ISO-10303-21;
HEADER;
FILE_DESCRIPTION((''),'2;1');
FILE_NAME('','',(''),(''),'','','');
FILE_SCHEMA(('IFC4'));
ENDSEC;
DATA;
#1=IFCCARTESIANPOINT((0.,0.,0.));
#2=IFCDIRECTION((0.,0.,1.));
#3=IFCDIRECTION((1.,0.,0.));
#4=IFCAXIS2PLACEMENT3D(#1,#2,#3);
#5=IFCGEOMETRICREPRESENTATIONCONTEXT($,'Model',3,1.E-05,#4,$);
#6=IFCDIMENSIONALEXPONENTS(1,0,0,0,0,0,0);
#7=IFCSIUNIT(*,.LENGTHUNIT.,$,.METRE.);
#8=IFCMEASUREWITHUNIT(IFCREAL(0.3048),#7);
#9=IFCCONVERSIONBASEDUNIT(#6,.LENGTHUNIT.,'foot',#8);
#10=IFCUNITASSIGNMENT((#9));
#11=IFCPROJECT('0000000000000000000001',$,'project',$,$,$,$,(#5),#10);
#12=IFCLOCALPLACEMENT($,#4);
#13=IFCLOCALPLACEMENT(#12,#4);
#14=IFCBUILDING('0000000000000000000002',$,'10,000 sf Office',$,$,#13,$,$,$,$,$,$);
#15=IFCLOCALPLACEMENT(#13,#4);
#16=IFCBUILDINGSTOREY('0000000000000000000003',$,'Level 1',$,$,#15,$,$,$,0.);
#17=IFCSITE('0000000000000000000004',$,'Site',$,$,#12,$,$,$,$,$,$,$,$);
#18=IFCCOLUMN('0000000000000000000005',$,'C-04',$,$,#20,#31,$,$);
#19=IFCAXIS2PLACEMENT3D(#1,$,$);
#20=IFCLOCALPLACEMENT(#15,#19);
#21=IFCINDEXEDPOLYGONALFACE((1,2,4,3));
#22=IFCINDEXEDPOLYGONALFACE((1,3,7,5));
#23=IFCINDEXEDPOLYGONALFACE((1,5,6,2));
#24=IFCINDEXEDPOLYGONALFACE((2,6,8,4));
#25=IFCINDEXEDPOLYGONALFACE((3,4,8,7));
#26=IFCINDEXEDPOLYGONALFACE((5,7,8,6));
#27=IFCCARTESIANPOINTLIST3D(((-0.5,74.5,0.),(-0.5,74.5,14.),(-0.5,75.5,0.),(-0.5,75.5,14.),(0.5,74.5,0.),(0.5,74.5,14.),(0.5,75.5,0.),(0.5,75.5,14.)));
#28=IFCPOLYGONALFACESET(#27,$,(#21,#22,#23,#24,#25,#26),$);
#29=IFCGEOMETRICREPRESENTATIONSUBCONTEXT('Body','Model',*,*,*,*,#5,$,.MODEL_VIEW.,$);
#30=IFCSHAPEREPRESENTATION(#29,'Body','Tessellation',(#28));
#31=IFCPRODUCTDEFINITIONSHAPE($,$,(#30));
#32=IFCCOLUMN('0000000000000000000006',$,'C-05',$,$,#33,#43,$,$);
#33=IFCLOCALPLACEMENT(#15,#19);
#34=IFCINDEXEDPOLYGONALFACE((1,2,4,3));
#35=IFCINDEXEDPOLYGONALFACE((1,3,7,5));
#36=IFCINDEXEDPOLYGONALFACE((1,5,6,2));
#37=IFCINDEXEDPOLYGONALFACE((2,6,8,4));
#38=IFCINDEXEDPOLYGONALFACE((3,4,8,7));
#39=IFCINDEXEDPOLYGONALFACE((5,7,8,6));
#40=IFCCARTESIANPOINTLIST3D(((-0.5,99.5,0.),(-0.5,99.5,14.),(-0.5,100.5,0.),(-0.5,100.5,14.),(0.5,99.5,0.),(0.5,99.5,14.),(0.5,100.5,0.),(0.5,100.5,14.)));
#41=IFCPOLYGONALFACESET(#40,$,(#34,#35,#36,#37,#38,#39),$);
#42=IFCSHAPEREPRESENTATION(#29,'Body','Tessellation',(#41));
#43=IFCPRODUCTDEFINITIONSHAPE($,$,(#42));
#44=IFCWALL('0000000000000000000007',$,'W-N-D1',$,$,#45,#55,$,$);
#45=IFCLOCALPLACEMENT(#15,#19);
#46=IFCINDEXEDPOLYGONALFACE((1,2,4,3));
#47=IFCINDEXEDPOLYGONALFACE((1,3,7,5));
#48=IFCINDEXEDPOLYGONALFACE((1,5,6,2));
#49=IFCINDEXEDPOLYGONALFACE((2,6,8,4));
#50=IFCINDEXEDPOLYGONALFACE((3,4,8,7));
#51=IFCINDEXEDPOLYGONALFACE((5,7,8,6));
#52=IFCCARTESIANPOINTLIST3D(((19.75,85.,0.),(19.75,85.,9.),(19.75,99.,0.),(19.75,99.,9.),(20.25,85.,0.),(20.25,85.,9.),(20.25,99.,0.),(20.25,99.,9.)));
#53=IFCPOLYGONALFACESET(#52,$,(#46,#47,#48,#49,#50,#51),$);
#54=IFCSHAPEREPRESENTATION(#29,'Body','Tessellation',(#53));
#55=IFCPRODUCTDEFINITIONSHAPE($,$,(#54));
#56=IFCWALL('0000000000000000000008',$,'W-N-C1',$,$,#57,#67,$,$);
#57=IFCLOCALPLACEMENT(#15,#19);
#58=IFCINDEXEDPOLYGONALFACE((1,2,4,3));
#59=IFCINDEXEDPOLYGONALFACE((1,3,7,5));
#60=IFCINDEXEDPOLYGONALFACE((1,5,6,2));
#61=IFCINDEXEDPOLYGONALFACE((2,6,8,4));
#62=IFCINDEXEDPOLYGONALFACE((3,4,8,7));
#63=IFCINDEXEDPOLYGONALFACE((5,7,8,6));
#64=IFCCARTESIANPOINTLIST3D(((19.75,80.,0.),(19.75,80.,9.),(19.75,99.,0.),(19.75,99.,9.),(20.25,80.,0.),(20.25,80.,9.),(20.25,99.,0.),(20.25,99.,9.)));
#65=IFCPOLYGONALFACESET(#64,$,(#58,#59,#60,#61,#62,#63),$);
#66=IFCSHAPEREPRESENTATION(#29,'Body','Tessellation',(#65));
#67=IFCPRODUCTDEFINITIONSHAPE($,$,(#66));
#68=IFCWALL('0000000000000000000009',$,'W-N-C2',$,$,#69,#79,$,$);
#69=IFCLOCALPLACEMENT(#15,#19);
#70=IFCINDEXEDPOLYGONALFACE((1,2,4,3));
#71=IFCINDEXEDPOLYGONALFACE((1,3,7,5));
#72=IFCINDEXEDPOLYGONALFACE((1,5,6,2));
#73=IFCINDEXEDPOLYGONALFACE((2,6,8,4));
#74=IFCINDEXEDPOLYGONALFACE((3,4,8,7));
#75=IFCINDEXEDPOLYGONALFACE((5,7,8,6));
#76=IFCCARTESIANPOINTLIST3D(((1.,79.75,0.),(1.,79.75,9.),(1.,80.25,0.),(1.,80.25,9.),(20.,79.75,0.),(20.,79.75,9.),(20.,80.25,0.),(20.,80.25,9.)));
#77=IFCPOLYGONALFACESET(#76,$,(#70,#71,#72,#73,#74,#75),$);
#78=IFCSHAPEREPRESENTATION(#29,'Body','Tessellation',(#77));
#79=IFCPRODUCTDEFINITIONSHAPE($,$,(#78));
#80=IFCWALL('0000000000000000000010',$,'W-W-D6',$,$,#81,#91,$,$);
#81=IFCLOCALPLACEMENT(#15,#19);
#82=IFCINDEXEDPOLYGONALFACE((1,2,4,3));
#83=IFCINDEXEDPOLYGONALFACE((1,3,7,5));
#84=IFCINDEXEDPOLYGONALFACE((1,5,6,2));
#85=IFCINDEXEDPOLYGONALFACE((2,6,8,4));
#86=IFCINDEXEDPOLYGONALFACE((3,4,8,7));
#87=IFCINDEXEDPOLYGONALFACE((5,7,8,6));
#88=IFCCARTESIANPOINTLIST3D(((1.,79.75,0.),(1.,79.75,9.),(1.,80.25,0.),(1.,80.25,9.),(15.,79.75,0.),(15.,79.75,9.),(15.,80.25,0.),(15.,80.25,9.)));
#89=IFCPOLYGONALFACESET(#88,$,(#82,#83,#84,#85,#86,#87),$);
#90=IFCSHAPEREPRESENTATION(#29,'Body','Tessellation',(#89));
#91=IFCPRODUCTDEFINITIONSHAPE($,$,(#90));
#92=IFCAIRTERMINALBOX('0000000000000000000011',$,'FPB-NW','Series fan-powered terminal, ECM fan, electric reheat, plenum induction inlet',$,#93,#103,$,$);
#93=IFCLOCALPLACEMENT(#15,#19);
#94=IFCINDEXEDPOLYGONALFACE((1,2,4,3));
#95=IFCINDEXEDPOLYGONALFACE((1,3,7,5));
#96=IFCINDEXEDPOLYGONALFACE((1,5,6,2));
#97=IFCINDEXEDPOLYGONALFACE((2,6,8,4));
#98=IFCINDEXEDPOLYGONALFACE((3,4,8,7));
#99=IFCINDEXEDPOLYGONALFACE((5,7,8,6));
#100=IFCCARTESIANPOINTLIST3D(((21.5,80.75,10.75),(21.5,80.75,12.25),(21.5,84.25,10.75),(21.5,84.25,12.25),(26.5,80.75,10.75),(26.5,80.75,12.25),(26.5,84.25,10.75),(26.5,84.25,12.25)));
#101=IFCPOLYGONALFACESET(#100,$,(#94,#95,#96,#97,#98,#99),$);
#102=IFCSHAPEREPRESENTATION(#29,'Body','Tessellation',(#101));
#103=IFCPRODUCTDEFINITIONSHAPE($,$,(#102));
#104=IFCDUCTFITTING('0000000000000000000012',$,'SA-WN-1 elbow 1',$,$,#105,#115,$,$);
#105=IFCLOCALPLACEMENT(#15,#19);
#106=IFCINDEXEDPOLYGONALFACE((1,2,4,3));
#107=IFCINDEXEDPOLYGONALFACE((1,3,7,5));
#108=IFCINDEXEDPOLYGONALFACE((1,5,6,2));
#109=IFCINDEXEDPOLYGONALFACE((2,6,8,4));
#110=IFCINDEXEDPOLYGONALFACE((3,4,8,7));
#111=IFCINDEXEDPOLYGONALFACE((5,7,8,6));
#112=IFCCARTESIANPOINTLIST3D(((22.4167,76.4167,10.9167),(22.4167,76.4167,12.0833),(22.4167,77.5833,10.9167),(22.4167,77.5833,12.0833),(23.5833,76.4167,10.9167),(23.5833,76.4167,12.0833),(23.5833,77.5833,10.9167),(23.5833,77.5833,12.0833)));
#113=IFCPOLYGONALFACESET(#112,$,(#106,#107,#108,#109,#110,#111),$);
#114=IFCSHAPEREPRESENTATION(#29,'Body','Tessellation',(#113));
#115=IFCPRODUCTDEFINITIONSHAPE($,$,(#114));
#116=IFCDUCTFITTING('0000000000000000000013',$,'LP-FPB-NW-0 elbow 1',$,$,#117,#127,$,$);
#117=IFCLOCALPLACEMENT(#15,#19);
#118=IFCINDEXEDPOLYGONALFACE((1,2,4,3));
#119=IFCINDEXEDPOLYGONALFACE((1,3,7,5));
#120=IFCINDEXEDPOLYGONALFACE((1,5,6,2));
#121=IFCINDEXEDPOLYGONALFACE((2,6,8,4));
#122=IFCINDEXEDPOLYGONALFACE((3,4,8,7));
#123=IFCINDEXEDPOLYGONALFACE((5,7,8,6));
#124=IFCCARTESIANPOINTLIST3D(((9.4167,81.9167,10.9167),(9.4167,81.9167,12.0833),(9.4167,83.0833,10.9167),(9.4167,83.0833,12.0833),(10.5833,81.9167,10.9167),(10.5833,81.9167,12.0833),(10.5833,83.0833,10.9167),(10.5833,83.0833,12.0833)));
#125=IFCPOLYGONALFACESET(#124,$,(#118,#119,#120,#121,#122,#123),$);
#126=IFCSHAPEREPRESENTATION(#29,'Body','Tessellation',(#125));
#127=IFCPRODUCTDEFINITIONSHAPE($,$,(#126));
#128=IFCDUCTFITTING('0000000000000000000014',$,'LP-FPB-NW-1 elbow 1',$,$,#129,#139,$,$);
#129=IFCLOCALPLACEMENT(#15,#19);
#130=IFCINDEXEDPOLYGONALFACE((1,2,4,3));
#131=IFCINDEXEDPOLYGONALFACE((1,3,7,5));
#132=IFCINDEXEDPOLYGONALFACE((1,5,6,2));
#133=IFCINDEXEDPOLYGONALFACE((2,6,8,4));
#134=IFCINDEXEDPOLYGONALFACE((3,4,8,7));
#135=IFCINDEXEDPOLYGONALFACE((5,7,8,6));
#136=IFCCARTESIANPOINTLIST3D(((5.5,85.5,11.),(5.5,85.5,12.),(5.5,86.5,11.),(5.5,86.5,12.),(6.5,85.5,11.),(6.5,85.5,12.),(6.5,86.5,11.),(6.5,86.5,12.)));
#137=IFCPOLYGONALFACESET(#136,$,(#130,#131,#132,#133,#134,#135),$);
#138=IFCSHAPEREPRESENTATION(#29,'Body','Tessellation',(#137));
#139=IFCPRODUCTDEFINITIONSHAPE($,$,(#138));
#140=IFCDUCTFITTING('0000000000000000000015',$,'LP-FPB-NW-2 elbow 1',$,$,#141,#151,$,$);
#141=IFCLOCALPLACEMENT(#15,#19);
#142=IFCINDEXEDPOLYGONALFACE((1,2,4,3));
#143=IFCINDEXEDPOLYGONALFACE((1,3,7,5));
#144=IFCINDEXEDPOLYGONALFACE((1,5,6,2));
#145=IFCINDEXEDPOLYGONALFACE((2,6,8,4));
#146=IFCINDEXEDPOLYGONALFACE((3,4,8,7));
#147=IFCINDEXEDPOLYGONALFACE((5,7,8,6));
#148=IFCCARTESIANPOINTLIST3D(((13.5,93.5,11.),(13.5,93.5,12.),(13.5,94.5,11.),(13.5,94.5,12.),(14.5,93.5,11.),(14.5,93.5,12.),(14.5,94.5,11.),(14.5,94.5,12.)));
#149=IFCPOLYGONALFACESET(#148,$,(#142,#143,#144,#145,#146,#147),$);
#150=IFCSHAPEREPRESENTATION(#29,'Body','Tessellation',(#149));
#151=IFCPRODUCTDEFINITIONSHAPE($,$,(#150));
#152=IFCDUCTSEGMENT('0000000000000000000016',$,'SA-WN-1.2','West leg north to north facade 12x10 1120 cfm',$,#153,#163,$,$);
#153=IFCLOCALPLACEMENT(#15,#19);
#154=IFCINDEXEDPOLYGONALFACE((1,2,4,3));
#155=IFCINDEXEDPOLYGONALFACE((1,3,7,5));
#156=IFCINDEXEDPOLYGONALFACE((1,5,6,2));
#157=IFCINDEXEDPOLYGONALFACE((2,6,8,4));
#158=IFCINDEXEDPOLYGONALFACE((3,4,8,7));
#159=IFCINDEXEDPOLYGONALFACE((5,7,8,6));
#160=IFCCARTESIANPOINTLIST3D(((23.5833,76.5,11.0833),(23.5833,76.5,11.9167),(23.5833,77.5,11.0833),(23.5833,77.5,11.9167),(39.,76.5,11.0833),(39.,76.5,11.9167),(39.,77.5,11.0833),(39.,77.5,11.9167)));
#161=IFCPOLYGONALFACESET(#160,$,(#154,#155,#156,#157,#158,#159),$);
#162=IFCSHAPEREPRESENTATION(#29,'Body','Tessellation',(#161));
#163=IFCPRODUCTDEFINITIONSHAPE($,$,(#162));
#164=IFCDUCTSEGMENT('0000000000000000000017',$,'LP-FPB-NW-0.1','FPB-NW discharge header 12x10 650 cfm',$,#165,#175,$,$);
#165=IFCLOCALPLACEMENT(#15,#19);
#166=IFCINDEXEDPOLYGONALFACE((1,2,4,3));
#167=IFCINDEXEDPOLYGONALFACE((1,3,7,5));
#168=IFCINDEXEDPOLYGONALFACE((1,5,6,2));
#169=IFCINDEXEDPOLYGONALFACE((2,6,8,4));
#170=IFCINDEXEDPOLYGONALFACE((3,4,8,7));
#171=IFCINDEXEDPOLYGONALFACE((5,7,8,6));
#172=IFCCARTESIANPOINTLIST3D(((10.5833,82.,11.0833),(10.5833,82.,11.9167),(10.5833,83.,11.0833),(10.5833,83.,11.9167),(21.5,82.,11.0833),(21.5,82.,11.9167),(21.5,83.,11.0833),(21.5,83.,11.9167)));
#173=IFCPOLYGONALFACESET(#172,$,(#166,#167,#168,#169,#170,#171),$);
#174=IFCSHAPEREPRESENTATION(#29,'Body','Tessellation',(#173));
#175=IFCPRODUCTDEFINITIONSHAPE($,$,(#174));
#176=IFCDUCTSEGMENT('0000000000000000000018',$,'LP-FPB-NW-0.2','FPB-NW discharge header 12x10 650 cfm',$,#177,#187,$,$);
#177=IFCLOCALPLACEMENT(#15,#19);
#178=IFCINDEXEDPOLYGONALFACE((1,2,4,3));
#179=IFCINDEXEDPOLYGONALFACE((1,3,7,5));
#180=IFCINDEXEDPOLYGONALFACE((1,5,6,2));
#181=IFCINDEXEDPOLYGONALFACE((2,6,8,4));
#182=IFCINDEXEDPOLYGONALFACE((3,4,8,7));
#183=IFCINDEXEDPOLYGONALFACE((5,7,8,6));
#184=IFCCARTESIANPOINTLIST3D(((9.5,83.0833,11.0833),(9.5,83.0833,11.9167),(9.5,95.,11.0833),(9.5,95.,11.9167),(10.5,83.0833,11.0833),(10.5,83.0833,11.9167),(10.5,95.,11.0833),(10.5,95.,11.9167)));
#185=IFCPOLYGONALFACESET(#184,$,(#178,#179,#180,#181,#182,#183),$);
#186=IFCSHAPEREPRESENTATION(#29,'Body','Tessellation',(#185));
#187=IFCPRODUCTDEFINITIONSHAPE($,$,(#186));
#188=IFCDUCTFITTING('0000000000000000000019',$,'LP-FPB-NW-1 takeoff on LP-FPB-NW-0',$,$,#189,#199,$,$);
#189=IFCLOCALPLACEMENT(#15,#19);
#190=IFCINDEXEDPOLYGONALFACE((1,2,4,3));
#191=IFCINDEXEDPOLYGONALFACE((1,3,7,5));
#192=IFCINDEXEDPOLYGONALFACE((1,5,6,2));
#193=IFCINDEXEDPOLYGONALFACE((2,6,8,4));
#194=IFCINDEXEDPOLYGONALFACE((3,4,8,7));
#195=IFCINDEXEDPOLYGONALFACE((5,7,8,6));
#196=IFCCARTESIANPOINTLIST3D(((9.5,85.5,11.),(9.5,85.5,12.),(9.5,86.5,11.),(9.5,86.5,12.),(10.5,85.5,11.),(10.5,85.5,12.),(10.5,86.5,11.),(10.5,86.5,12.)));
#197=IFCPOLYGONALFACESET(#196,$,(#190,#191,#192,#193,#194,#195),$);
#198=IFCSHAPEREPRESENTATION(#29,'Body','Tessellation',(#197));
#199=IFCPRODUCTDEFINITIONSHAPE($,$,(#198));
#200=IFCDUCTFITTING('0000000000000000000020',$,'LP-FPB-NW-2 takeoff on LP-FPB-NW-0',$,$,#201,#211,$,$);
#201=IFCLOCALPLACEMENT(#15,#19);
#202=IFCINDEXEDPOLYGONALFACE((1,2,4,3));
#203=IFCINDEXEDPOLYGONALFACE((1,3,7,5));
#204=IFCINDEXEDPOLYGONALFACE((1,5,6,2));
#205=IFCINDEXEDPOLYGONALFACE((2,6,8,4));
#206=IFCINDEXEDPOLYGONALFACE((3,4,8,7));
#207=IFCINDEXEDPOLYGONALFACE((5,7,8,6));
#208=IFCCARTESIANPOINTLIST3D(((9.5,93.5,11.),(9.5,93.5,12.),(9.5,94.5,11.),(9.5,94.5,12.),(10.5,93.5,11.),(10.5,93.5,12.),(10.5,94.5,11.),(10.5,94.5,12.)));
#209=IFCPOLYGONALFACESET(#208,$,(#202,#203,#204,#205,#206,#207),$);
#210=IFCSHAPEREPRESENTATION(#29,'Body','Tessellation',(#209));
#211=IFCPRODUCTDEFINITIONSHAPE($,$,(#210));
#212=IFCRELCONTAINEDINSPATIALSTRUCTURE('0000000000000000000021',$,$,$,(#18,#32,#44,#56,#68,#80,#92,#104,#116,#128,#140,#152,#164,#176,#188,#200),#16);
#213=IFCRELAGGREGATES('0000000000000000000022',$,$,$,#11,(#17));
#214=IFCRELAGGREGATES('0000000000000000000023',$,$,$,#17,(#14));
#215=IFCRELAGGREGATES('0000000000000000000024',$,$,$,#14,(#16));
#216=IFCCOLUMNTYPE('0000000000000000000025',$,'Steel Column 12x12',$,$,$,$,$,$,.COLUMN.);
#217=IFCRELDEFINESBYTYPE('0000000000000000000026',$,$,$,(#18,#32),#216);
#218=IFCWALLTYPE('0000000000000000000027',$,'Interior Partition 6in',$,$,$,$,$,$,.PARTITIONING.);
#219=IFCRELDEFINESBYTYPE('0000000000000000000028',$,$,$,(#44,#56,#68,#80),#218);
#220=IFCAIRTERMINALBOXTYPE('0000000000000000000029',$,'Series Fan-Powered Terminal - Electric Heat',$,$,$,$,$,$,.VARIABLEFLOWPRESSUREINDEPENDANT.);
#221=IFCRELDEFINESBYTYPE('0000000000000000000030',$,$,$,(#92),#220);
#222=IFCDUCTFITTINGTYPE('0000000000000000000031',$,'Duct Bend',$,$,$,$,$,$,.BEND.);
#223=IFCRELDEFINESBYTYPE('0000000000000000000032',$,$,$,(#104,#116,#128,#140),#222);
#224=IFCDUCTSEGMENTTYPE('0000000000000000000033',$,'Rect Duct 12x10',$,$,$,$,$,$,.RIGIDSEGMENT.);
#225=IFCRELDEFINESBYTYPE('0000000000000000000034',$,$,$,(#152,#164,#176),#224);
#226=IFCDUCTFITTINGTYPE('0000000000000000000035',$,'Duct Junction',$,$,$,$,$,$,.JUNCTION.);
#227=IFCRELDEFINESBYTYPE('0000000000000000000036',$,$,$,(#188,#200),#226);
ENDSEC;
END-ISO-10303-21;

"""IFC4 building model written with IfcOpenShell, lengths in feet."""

from ifc_helpers import new_model, entity, si_unit, converted_unit, frame, origin_with_axes, place, context, subcontext, project, spatial, rectangle, extrude, type_object, element, save


model = new_model("IFC4")

# Units and contexts
model_context = context("Model", 3, precision=1e-05, world=origin_with_axes())
body_context = subcontext(model_context, "Body", "Model", "MODEL_VIEW")
ifc_project = project(units=[converted_unit("LENGTHUNIT", "foot", entity("IfcReal", 0.3048), si_unit("LENGTHUNIT", "METRE"), dimensions=[1, 0, 0, 0, 0, 0, 0])], contexts=[model_context])

# Site, building, storey
site_placement = place(None, origin_with_axes())
site = spatial("IfcSite", under=ifc_project, at=site_placement, Name="Site")
building_placement = place(site_placement, origin_with_axes())
building = spatial("IfcBuilding", under=site, at=building_placement, Name="10,000 sf Office")
storey_placement = place(building_placement, origin_with_axes())
storey = spatial("IfcBuildingStorey", under=building, at=storey_placement, Name="Level 1", Elevation=0.0)

# Columns
column_type = type_object("IfcColumnType", Name="Steel Column 12x12", PredefinedType="COLUMN")
for number, where, z_axis, x_axis, name in (
    (1, (0.0, 75.0, 0.0), (0.0, 0.0, 1.0), (1.0, 0.0, 0.0), "C-04"),
    (2, (0.0, 100.0, 0.0), (0.0, 0.0, 1.0), (1.0, 0.0, 0.0), "C-05"),
):
    element("IfcColumn", number, at=place(storey_placement, frame(where, z_axis=z_axis, x_axis=x_axis)), inside=storey, type_object=column_type, Name=name, context=body_context, shape_type="SweptSolid", body=[
        extrude(rectangle(XDim=1.0, YDim=1.0), None, (0.0, 0.0, 1.0), 14.0),
    ])

# Walls
wall_type = type_object("IfcWallType", Name="Interior Partition 6in", PredefinedType="PARTITIONING")
wall_1_placement = place(storey_placement, frame((20.0, 92.0, 0.0), z_axis=(0.0, 0.0, 1.0), x_axis=(0.0, -1.0, 0.0)))
element("IfcWall", 3, at=wall_1_placement, inside=storey, type_object=wall_type, Name="W-N-D1", context=body_context, shape_type="SweptSolid", body=[
    extrude(rectangle(XDim=14.0, YDim=0.5), None, (0.0, 0.0, 1.0), 9.0),
])
for number, where, z_axis, x_axis, name in (
    (4, (20.0, 89.5, 0.0), (0.0, 0.0, 1.0), (0.0, -1.0, 0.0), "W-N-C1"),
    (5, (10.5, 80.0, 0.0), (0.0, 0.0, 1.0), (-1.0, 0.0, 0.0), "W-N-C2"),
):
    element("IfcWall", number, at=place(storey_placement, frame(where, z_axis=z_axis, x_axis=x_axis)), inside=storey, type_object=wall_type, Name=name, context=body_context, shape_type="SweptSolid", body=[
        extrude(rectangle(XDim=19.0, YDim=0.5), None, (0.0, 0.0, 1.0), 9.0),
    ])
wall_2_placement = place(storey_placement, frame((8.0, 80.0, 0.0), z_axis=(0.0, 0.0, 1.0), x_axis=(1.0, 0.0, 0.0)))
element("IfcWall", 6, at=wall_2_placement, inside=storey, type_object=wall_type, Name="W-W-D6", context=body_context, shape_type="SweptSolid", body=[
    extrude(rectangle(XDim=14.0, YDim=0.5), None, (0.0, 0.0, 1.0), 9.0),
])

# Air terminal box
air_terminal_box_type = type_object("IfcAirTerminalBoxType", Name="Series Fan-Powered Terminal - Electric Heat", PredefinedType="VARIABLEFLOWPRESSUREINDEPENDANT")
air_terminal_box_placement = place(storey_placement, frame((24.0, 82.5, 10.75), z_axis=(0.0, 0.0, 1.0), x_axis=(-1.0, 0.0, 0.0)))
element("IfcAirTerminalBox", 7, at=air_terminal_box_placement, inside=storey, type_object=air_terminal_box_type, Name="FPB-NW", Description="Series fan-powered terminal, ECM fan, electric reheat, plenum induction inlet", context=body_context, shape_type="SweptSolid", body=[
    extrude(rectangle(XDim=5.0, YDim=3.5), None, (0.0, 0.0, 1.0), 1.5),
])

# Duct fittings
duct_fitting_type_1 = type_object("IfcDuctFittingType", Name="Duct Bend", PredefinedType="BEND")
for number, where, z_axis, x_axis, name in (
    (8, (23.0, 77.0, 10.9167), (0.0, 0.0, 1.0), (1.0, 0.0, 0.0), "SA-WN-1 elbow 1"),
    (9, (10.0, 82.5, 10.9167), (0.0, 0.0, 1.0), (1.0, 0.0, 0.0), "LP-FPB-NW-0 elbow 1"),
):
    element("IfcDuctFitting", number, at=place(storey_placement, frame(where, z_axis=z_axis, x_axis=x_axis)), inside=storey, type_object=duct_fitting_type_1, Name=name, context=body_context, shape_type="SweptSolid", body=[
        extrude(rectangle(XDim=1.1667, YDim=1.1667), None, (0.0, 0.0, 1.0), 1.1667),
    ])
for number, where, z_axis, x_axis, name in (
    (10, (6.0, 86.0, 11.0), (0.0, 0.0, 1.0), (1.0, 0.0, 0.0), "LP-FPB-NW-1 elbow 1"),
    (11, (14.0, 94.0, 11.0), (0.0, 0.0, 1.0), (1.0, 0.0, 0.0), "LP-FPB-NW-2 elbow 1"),
):
    element("IfcDuctFitting", number, at=place(storey_placement, frame(where, z_axis=z_axis, x_axis=x_axis)), inside=storey, type_object=duct_fitting_type_1, Name=name, context=body_context, shape_type="SweptSolid", body=[
        extrude(rectangle(XDim=1.0, YDim=1.0), None, (0.0, 0.0, 1.0), 1.0),
    ])

# Duct segments
duct_segment_type_1 = type_object("IfcDuctSegmentType", Name="Rect Duct 12x10", PredefinedType="RIGIDSEGMENT")
duct_segment_1_placement = place(storey_placement, frame((23.5833, 77.0, 11.5), z_axis=(1.0, 0.0, 0.0), x_axis=(0.0, 1.0, 0.0)))
element("IfcDuctSegment", 12, at=duct_segment_1_placement, inside=storey, type_object=duct_segment_type_1, Name="SA-WN-1.2", Description="West leg north to north facade 12x10 1120 cfm", context=body_context, shape_type="SweptSolid", body=[
    extrude(rectangle(XDim=1.0, YDim=0.8333), None, (0.0, 0.0, 1.0), 15.4167),
])
duct_segment_2_placement = place(storey_placement, frame((21.5, 82.5, 11.5), z_axis=(-1.0, 0.0, 0.0), x_axis=(0.0, -1.0, 0.0)))
element("IfcDuctSegment", 13, at=duct_segment_2_placement, inside=storey, type_object=duct_segment_type_1, Name="LP-FPB-NW-0.1", Description="FPB-NW discharge header 12x10 650 cfm", context=body_context, shape_type="SweptSolid", body=[
    extrude(rectangle(XDim=1.0, YDim=0.8333), None, (0.0, 0.0, 1.0), 10.9167),
])
duct_segment_3_placement = place(storey_placement, frame((10.0, 83.0833, 11.5), z_axis=(0.0, 1.0, 0.0), x_axis=(-1.0, 0.0, 0.0)))
element("IfcDuctSegment", 14, at=duct_segment_3_placement, inside=storey, type_object=duct_segment_type_1, Name="LP-FPB-NW-0.2", Description="FPB-NW discharge header 12x10 650 cfm", context=body_context, shape_type="SweptSolid", body=[
    extrude(rectangle(XDim=1.0, YDim=0.8333), None, (0.0, 0.0, 1.0), 11.9167),
])

# Duct fittings
duct_fitting_type_2 = type_object("IfcDuctFittingType", Name="Duct Junction", PredefinedType="JUNCTION")
for number, where, z_axis, x_axis, name in (
    (15, (10.0, 86.0, 11.0), (0.0, 0.0, 1.0), (1.0, 0.0, 0.0), "LP-FPB-NW-1 takeoff on LP-FPB-NW-0"),
    (16, (10.0, 94.0, 11.0), (0.0, 0.0, 1.0), (1.0, 0.0, 0.0), "LP-FPB-NW-2 takeoff on LP-FPB-NW-0"),
):
    element("IfcDuctFitting", number, at=place(storey_placement, frame(where, z_axis=z_axis, x_axis=x_axis)), inside=storey, type_object=duct_fitting_type_2, Name=name, context=body_context, shape_type="SweptSolid", body=[
        extrude(rectangle(XDim=1.0, YDim=1.0), None, (0.0, 0.0, 1.0), 1.0),
    ])

save(model, "model.ifc")
